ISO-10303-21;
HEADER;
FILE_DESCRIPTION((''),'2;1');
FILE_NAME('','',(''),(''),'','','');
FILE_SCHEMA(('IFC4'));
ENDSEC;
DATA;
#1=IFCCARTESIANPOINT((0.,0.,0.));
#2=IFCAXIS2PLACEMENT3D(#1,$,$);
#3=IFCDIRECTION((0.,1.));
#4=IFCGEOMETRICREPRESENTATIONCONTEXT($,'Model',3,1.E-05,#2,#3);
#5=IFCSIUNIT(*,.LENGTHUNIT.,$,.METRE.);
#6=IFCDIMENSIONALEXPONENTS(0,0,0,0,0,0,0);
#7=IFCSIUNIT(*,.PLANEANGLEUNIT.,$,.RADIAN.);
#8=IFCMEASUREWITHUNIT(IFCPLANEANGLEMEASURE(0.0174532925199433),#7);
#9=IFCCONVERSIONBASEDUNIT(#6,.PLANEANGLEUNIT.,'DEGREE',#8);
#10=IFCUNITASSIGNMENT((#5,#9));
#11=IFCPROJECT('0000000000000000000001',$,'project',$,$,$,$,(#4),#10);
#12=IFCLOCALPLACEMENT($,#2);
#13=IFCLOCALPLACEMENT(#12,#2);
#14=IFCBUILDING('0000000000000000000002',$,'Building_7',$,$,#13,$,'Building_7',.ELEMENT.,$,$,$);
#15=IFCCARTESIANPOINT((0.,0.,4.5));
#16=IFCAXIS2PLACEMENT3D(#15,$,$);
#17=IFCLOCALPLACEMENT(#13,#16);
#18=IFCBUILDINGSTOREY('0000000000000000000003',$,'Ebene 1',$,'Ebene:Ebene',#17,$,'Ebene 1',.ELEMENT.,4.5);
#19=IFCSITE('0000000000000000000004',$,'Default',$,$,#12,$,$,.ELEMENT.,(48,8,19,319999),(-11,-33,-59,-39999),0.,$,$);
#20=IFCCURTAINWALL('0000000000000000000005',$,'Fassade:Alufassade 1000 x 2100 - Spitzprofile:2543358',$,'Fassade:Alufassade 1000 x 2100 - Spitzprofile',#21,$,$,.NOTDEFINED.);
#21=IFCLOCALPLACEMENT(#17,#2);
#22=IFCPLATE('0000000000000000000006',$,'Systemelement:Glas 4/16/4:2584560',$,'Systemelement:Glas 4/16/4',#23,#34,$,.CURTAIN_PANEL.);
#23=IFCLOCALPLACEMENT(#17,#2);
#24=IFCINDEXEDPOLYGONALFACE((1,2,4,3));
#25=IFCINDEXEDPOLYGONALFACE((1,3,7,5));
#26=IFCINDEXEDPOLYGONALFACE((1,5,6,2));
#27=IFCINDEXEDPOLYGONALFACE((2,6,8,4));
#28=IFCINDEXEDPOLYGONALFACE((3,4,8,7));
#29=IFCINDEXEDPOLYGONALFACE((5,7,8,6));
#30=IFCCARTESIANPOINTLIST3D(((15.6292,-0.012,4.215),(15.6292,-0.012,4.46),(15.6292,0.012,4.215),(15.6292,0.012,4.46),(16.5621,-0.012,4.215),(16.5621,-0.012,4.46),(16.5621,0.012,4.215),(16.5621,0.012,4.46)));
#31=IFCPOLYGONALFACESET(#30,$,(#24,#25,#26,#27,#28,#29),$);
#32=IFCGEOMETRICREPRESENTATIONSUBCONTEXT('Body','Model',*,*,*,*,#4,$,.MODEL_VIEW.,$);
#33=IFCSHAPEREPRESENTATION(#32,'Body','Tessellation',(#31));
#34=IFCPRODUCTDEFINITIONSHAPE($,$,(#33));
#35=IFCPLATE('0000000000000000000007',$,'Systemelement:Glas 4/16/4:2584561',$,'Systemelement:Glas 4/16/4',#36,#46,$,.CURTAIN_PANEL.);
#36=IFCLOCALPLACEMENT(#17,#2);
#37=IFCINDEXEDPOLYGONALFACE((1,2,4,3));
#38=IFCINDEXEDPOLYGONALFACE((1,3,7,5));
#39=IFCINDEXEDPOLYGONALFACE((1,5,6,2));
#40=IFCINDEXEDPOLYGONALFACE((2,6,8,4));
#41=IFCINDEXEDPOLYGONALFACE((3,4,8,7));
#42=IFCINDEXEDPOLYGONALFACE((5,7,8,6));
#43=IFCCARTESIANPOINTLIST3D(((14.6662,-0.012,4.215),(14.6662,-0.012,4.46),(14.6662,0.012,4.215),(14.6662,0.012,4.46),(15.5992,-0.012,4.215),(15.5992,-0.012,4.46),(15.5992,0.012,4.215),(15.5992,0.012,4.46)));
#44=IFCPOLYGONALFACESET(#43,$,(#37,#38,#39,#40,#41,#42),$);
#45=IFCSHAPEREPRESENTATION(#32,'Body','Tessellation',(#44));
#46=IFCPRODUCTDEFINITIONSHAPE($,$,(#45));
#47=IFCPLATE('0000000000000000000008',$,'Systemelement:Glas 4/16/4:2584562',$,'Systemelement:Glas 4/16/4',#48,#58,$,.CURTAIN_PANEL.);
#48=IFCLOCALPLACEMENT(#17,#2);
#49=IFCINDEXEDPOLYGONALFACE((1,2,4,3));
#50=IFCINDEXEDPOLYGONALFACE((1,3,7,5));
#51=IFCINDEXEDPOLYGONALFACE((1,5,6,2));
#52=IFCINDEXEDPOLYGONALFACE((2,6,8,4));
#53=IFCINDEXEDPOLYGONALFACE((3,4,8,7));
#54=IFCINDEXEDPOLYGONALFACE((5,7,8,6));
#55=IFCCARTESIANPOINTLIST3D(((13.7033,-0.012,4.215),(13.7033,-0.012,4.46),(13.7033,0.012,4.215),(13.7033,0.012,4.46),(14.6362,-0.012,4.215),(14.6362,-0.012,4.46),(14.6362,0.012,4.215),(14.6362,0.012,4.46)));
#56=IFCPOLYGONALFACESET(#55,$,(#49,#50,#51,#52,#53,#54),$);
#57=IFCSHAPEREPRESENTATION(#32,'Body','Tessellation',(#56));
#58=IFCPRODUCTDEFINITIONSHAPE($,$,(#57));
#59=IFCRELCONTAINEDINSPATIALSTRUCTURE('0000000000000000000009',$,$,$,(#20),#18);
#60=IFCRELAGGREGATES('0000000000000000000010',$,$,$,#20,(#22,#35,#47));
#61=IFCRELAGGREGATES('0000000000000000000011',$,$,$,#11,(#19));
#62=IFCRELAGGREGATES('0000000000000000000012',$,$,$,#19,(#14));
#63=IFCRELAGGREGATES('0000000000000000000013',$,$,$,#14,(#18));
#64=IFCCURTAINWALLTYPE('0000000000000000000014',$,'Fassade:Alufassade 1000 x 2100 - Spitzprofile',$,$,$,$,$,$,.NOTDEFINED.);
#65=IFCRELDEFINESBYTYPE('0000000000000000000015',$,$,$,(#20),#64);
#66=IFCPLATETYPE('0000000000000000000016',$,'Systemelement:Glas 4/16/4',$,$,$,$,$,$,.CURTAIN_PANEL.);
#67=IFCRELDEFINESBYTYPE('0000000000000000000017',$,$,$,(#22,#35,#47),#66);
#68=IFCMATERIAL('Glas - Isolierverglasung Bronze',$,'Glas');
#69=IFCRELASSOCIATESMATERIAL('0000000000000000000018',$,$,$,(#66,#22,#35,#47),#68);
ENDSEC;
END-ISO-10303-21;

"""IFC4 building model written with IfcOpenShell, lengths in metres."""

from ifc_helpers import new_model, entity, si_unit, converted_unit, direction, frame, origin, place, context, subcontext, project, spatial, indexed_curve, outline, extrude, source, transform, mapped, material, type_object, type_shapes, element, aggregate, save


model = new_model("IFC4")

# Units and contexts
model_context = context("Model", 3, precision=1e-05, world=origin(), true_north=direction((0.0, 1.0)))
body_context = subcontext(model_context, "Body", "Model", "MODEL_VIEW")
ifc_project = project(units=[si_unit("LENGTHUNIT", "METRE"), converted_unit("PLANEANGLEUNIT", "DEGREE", entity("IfcPlaneAngleMeasure", 0.0174532925199433), si_unit("PLANEANGLEUNIT", "RADIAN"), dimensions=[0, 0, 0, 0, 0, 0, 0])], contexts=[model_context])

# Site, building, storey
site_placement = place(None, origin())
site = spatial("IfcSite", under=ifc_project, at=site_placement, Name="Default", CompositionType="ELEMENT", RefLatitude=(48, 8, 19, 319999), RefLongitude=(-11, -33, -59, -39999), RefElevation=0.0)
building_placement = place(site_placement, origin())
building = spatial("IfcBuilding", under=site, at=building_placement, Name="Building_7", LongName="Building_7", CompositionType="ELEMENT")
storey_placement = place(building_placement, frame((0.0, 0.0, 4.5)))
storey = spatial("IfcBuildingStorey", under=building, at=storey_placement, Name="Ebene 1", ObjectType="Ebene:Ebene", LongName="Ebene 1", CompositionType="ELEMENT", Elevation=4.5)

# Curtain wall, plates
curtain_wall_type = type_object("IfcCurtainWallType", Name="Fassade:Alufassade 1000 x 2100 - Spitzprofile", PredefinedType="NOTDEFINED")
curtain_wall_placement = place(storey_placement, frame((0.0, 0.0, -4.5)))
curtain_wall = element("IfcCurtainWall", 1, at=curtain_wall_placement, inside=storey, type_object=curtain_wall_type, Name="Fassade:Alufassade 1000 x 2100 - Spitzprofile:2543358", ObjectType="Fassade:Alufassade 1000 x 2100 - Spitzprofile", PredefinedType="NOTDEFINED")
ifc_material_1 = material(Name="Glas - Isolierverglasung Bronze", Category="Glas")
plate_type_1 = type_object("IfcPlateType", Name="Systemelement:Glas 4/16/4", PredefinedType="CURTAIN_PANEL", material=ifc_material_1)
shared_shape_1 = source(origin(), body_context, "Body", "SweptSolid", [
    extrude(outline(indexed_curve([(-0.012, -0.4665), (0.012, -0.4665), (0.012, 0.4665), (-0.012, 0.4665), (-0.012, -0.4665)], self_intersect=False)), frame((0.0, 0.0, 0.0), z_axis=(0.0, 0.0, 1.0), x_axis=(0.0, 1.0, 0.0)), (0.0, 0.0, 1.0), 0.245),
])
type_shapes(plate_type_1, [shared_shape_1])
plate_1_placement = place(curtain_wall_placement, frame((16.0956, 0.0, 8.715), z_axis=(0.0, 0.0, 1.0), x_axis=(-1.0, 0.0, 0.0)))
plate_1 = element("IfcPlate", 2, at=plate_1_placement, type_object=plate_type_1, material=ifc_material_1, Name="Systemelement:Glas 4/16/4:2584560", ObjectType="Systemelement:Glas 4/16/4", PredefinedType="CURTAIN_PANEL", context=body_context, shape_type="MappedRepresentation", body=[
    mapped(shared_shape_1, transform((0.0, 0.0, 0.0), scale=1.0)),
])
plate_2_placement = place(curtain_wall_placement, frame((15.1327, 0.0, 8.715), z_axis=(0.0, 0.0, 1.0), x_axis=(-1.0, 0.0, 0.0)))
plate_2 = element("IfcPlate", 3, at=plate_2_placement, type_object=plate_type_1, material=ifc_material_1, Name="Systemelement:Glas 4/16/4:2584561", ObjectType="Systemelement:Glas 4/16/4", PredefinedType="CURTAIN_PANEL", context=body_context, shape_type="MappedRepresentation", body=[
    mapped(shared_shape_1, transform((0.0, 0.0, 0.0), scale=1.0)),
])
plate_3_placement = place(curtain_wall_placement, frame((14.1698, 0.0, 8.715), z_axis=(0.0, 0.0, 1.0), x_axis=(-1.0, 0.0, 0.0)))
plate_3 = element("IfcPlate", 4, at=plate_3_placement, type_object=plate_type_1, material=ifc_material_1, Name="Systemelement:Glas 4/16/4:2584562", ObjectType="Systemelement:Glas 4/16/4", PredefinedType="CURTAIN_PANEL", context=body_context, shape_type="MappedRepresentation", body=[
    mapped(shared_shape_1, transform((0.0, 0.0, 0.0), scale=1.0)),
])
aggregate(curtain_wall, [plate_1, plate_2, plate_3])

save(model, "model.ifc")
